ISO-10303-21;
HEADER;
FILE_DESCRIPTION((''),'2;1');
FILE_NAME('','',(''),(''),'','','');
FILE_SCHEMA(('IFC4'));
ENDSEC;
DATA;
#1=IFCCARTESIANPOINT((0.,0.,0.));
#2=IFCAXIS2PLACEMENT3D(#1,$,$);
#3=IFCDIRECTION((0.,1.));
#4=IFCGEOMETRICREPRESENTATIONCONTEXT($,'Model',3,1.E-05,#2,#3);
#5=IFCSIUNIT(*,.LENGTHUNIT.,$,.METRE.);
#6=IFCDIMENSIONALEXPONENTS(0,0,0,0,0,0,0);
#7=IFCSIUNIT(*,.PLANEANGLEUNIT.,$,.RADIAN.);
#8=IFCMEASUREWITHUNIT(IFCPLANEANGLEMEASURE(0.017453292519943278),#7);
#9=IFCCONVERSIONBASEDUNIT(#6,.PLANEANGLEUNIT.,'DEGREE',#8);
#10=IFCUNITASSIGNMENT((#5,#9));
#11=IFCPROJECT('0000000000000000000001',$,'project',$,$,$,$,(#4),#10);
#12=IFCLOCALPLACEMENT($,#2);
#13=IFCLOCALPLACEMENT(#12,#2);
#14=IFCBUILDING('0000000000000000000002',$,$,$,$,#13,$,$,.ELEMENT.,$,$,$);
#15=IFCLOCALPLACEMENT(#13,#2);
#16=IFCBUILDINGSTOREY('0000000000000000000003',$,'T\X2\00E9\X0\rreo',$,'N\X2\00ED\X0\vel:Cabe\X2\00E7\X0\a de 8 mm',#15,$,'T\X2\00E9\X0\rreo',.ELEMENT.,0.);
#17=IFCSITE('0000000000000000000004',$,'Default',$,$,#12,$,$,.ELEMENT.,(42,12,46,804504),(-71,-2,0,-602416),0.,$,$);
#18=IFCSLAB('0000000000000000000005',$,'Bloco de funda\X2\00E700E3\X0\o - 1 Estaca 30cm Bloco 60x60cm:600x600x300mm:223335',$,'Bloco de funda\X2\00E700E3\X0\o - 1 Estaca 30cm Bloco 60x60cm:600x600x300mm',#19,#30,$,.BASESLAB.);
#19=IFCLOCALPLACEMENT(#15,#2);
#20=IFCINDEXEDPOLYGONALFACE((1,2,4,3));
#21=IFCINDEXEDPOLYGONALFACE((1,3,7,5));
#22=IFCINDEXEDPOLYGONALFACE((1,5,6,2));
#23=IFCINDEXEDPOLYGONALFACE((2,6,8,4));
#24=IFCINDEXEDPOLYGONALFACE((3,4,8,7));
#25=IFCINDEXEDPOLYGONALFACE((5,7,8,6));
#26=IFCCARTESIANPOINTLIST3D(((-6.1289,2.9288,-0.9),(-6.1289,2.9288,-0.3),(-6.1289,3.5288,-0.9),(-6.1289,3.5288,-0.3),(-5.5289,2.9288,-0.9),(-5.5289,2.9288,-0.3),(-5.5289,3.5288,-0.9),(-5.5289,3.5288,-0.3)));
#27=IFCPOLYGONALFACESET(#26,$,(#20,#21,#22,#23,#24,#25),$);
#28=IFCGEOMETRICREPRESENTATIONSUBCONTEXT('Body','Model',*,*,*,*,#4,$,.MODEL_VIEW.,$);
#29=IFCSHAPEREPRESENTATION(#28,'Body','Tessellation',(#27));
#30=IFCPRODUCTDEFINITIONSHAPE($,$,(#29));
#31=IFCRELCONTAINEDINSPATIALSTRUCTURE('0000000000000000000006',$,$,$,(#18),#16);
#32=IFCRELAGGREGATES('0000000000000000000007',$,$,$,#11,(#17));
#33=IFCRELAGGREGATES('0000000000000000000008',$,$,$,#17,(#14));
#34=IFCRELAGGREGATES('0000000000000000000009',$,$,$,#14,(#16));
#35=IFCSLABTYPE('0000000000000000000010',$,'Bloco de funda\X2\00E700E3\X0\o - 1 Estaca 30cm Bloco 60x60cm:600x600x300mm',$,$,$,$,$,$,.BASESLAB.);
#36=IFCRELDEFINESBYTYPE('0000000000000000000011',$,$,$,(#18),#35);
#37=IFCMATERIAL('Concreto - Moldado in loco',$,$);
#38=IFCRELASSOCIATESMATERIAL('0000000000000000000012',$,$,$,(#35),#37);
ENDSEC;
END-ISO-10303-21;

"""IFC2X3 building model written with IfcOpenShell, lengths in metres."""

from ifc_helpers import new_model, entity, si_unit, converted_unit, direction, frame, origin, origin_2d_with_axis, place, context, subcontext, project, spatial, rectangle, extrude, material, type_object, element, save


model = new_model("IFC2X3")

# Units and contexts
model_context = context("Model", 3, precision=1e-05, world=origin(), true_north=direction((0.0, 1.0)))
body_context = subcontext(model_context, "Body", "Model", "MODEL_VIEW")
ifc_project = project(units=[si_unit("LENGTHUNIT", "METRE"), converted_unit("PLANEANGLEUNIT", "DEGREE", entity("IfcPlaneAngleMeasure", 0.017453292519943278), si_unit("PLANEANGLEUNIT", "RADIAN"), dimensions=[0, 0, 0, 0, 0, 0, 0])], contexts=[model_context])

# Site, building, storey
site_placement = place(None, origin())
site = spatial("IfcSite", under=ifc_project, at=site_placement, Name="Default", CompositionType="ELEMENT", RefLatitude=(42, 12, 46, 804504), RefLongitude=(-71, -2, 0, -602416), RefElevation=0.0)
building_placement = place(site_placement, origin())
building = spatial("IfcBuilding", under=site, at=building_placement, CompositionType="ELEMENT")
storey_placement = place(building_placement, origin())
storey = spatial("IfcBuildingStorey", under=building, at=storey_placement, Name="Térreo", ObjectType="Nível:Cabeça de 8 mm", LongName="Térreo", CompositionType="ELEMENT", Elevation=0.0)

# Slab
ifc_material_1 = material(Name="Concreto - Moldado in loco")
slab_type_1 = type_object("IfcSlabType", Name="Bloco de fundação - 1 Estaca 30cm Bloco 60x60cm:600x600x300mm", PredefinedType="BASESLAB", material=ifc_material_1)
slab_1_placement = place(storey_placement, origin())
element("IfcSlab", 1, at=slab_1_placement, inside=storey, type_object=slab_type_1, Name="Bloco de fundação - 1 Estaca 30cm Bloco 60x60cm:600x600x300mm:223335", ObjectType="Bloco de fundação - 1 Estaca 30cm Bloco 60x60cm:600x600x300mm", PredefinedType="BASESLAB", context=body_context, shape_type="SweptSolid", body=[
    extrude(rectangle(XDim=0.6, YDim=0.6, at=origin_2d_with_axis()), frame((-5.8289, 3.2288, -0.9), z_axis=(0.0, 0.0, 1.0), x_axis=(-1.0, 0.0, 0.0)), (0.0, 0.0, 1.0), 0.6),
])

save(model, "model.ifc")
